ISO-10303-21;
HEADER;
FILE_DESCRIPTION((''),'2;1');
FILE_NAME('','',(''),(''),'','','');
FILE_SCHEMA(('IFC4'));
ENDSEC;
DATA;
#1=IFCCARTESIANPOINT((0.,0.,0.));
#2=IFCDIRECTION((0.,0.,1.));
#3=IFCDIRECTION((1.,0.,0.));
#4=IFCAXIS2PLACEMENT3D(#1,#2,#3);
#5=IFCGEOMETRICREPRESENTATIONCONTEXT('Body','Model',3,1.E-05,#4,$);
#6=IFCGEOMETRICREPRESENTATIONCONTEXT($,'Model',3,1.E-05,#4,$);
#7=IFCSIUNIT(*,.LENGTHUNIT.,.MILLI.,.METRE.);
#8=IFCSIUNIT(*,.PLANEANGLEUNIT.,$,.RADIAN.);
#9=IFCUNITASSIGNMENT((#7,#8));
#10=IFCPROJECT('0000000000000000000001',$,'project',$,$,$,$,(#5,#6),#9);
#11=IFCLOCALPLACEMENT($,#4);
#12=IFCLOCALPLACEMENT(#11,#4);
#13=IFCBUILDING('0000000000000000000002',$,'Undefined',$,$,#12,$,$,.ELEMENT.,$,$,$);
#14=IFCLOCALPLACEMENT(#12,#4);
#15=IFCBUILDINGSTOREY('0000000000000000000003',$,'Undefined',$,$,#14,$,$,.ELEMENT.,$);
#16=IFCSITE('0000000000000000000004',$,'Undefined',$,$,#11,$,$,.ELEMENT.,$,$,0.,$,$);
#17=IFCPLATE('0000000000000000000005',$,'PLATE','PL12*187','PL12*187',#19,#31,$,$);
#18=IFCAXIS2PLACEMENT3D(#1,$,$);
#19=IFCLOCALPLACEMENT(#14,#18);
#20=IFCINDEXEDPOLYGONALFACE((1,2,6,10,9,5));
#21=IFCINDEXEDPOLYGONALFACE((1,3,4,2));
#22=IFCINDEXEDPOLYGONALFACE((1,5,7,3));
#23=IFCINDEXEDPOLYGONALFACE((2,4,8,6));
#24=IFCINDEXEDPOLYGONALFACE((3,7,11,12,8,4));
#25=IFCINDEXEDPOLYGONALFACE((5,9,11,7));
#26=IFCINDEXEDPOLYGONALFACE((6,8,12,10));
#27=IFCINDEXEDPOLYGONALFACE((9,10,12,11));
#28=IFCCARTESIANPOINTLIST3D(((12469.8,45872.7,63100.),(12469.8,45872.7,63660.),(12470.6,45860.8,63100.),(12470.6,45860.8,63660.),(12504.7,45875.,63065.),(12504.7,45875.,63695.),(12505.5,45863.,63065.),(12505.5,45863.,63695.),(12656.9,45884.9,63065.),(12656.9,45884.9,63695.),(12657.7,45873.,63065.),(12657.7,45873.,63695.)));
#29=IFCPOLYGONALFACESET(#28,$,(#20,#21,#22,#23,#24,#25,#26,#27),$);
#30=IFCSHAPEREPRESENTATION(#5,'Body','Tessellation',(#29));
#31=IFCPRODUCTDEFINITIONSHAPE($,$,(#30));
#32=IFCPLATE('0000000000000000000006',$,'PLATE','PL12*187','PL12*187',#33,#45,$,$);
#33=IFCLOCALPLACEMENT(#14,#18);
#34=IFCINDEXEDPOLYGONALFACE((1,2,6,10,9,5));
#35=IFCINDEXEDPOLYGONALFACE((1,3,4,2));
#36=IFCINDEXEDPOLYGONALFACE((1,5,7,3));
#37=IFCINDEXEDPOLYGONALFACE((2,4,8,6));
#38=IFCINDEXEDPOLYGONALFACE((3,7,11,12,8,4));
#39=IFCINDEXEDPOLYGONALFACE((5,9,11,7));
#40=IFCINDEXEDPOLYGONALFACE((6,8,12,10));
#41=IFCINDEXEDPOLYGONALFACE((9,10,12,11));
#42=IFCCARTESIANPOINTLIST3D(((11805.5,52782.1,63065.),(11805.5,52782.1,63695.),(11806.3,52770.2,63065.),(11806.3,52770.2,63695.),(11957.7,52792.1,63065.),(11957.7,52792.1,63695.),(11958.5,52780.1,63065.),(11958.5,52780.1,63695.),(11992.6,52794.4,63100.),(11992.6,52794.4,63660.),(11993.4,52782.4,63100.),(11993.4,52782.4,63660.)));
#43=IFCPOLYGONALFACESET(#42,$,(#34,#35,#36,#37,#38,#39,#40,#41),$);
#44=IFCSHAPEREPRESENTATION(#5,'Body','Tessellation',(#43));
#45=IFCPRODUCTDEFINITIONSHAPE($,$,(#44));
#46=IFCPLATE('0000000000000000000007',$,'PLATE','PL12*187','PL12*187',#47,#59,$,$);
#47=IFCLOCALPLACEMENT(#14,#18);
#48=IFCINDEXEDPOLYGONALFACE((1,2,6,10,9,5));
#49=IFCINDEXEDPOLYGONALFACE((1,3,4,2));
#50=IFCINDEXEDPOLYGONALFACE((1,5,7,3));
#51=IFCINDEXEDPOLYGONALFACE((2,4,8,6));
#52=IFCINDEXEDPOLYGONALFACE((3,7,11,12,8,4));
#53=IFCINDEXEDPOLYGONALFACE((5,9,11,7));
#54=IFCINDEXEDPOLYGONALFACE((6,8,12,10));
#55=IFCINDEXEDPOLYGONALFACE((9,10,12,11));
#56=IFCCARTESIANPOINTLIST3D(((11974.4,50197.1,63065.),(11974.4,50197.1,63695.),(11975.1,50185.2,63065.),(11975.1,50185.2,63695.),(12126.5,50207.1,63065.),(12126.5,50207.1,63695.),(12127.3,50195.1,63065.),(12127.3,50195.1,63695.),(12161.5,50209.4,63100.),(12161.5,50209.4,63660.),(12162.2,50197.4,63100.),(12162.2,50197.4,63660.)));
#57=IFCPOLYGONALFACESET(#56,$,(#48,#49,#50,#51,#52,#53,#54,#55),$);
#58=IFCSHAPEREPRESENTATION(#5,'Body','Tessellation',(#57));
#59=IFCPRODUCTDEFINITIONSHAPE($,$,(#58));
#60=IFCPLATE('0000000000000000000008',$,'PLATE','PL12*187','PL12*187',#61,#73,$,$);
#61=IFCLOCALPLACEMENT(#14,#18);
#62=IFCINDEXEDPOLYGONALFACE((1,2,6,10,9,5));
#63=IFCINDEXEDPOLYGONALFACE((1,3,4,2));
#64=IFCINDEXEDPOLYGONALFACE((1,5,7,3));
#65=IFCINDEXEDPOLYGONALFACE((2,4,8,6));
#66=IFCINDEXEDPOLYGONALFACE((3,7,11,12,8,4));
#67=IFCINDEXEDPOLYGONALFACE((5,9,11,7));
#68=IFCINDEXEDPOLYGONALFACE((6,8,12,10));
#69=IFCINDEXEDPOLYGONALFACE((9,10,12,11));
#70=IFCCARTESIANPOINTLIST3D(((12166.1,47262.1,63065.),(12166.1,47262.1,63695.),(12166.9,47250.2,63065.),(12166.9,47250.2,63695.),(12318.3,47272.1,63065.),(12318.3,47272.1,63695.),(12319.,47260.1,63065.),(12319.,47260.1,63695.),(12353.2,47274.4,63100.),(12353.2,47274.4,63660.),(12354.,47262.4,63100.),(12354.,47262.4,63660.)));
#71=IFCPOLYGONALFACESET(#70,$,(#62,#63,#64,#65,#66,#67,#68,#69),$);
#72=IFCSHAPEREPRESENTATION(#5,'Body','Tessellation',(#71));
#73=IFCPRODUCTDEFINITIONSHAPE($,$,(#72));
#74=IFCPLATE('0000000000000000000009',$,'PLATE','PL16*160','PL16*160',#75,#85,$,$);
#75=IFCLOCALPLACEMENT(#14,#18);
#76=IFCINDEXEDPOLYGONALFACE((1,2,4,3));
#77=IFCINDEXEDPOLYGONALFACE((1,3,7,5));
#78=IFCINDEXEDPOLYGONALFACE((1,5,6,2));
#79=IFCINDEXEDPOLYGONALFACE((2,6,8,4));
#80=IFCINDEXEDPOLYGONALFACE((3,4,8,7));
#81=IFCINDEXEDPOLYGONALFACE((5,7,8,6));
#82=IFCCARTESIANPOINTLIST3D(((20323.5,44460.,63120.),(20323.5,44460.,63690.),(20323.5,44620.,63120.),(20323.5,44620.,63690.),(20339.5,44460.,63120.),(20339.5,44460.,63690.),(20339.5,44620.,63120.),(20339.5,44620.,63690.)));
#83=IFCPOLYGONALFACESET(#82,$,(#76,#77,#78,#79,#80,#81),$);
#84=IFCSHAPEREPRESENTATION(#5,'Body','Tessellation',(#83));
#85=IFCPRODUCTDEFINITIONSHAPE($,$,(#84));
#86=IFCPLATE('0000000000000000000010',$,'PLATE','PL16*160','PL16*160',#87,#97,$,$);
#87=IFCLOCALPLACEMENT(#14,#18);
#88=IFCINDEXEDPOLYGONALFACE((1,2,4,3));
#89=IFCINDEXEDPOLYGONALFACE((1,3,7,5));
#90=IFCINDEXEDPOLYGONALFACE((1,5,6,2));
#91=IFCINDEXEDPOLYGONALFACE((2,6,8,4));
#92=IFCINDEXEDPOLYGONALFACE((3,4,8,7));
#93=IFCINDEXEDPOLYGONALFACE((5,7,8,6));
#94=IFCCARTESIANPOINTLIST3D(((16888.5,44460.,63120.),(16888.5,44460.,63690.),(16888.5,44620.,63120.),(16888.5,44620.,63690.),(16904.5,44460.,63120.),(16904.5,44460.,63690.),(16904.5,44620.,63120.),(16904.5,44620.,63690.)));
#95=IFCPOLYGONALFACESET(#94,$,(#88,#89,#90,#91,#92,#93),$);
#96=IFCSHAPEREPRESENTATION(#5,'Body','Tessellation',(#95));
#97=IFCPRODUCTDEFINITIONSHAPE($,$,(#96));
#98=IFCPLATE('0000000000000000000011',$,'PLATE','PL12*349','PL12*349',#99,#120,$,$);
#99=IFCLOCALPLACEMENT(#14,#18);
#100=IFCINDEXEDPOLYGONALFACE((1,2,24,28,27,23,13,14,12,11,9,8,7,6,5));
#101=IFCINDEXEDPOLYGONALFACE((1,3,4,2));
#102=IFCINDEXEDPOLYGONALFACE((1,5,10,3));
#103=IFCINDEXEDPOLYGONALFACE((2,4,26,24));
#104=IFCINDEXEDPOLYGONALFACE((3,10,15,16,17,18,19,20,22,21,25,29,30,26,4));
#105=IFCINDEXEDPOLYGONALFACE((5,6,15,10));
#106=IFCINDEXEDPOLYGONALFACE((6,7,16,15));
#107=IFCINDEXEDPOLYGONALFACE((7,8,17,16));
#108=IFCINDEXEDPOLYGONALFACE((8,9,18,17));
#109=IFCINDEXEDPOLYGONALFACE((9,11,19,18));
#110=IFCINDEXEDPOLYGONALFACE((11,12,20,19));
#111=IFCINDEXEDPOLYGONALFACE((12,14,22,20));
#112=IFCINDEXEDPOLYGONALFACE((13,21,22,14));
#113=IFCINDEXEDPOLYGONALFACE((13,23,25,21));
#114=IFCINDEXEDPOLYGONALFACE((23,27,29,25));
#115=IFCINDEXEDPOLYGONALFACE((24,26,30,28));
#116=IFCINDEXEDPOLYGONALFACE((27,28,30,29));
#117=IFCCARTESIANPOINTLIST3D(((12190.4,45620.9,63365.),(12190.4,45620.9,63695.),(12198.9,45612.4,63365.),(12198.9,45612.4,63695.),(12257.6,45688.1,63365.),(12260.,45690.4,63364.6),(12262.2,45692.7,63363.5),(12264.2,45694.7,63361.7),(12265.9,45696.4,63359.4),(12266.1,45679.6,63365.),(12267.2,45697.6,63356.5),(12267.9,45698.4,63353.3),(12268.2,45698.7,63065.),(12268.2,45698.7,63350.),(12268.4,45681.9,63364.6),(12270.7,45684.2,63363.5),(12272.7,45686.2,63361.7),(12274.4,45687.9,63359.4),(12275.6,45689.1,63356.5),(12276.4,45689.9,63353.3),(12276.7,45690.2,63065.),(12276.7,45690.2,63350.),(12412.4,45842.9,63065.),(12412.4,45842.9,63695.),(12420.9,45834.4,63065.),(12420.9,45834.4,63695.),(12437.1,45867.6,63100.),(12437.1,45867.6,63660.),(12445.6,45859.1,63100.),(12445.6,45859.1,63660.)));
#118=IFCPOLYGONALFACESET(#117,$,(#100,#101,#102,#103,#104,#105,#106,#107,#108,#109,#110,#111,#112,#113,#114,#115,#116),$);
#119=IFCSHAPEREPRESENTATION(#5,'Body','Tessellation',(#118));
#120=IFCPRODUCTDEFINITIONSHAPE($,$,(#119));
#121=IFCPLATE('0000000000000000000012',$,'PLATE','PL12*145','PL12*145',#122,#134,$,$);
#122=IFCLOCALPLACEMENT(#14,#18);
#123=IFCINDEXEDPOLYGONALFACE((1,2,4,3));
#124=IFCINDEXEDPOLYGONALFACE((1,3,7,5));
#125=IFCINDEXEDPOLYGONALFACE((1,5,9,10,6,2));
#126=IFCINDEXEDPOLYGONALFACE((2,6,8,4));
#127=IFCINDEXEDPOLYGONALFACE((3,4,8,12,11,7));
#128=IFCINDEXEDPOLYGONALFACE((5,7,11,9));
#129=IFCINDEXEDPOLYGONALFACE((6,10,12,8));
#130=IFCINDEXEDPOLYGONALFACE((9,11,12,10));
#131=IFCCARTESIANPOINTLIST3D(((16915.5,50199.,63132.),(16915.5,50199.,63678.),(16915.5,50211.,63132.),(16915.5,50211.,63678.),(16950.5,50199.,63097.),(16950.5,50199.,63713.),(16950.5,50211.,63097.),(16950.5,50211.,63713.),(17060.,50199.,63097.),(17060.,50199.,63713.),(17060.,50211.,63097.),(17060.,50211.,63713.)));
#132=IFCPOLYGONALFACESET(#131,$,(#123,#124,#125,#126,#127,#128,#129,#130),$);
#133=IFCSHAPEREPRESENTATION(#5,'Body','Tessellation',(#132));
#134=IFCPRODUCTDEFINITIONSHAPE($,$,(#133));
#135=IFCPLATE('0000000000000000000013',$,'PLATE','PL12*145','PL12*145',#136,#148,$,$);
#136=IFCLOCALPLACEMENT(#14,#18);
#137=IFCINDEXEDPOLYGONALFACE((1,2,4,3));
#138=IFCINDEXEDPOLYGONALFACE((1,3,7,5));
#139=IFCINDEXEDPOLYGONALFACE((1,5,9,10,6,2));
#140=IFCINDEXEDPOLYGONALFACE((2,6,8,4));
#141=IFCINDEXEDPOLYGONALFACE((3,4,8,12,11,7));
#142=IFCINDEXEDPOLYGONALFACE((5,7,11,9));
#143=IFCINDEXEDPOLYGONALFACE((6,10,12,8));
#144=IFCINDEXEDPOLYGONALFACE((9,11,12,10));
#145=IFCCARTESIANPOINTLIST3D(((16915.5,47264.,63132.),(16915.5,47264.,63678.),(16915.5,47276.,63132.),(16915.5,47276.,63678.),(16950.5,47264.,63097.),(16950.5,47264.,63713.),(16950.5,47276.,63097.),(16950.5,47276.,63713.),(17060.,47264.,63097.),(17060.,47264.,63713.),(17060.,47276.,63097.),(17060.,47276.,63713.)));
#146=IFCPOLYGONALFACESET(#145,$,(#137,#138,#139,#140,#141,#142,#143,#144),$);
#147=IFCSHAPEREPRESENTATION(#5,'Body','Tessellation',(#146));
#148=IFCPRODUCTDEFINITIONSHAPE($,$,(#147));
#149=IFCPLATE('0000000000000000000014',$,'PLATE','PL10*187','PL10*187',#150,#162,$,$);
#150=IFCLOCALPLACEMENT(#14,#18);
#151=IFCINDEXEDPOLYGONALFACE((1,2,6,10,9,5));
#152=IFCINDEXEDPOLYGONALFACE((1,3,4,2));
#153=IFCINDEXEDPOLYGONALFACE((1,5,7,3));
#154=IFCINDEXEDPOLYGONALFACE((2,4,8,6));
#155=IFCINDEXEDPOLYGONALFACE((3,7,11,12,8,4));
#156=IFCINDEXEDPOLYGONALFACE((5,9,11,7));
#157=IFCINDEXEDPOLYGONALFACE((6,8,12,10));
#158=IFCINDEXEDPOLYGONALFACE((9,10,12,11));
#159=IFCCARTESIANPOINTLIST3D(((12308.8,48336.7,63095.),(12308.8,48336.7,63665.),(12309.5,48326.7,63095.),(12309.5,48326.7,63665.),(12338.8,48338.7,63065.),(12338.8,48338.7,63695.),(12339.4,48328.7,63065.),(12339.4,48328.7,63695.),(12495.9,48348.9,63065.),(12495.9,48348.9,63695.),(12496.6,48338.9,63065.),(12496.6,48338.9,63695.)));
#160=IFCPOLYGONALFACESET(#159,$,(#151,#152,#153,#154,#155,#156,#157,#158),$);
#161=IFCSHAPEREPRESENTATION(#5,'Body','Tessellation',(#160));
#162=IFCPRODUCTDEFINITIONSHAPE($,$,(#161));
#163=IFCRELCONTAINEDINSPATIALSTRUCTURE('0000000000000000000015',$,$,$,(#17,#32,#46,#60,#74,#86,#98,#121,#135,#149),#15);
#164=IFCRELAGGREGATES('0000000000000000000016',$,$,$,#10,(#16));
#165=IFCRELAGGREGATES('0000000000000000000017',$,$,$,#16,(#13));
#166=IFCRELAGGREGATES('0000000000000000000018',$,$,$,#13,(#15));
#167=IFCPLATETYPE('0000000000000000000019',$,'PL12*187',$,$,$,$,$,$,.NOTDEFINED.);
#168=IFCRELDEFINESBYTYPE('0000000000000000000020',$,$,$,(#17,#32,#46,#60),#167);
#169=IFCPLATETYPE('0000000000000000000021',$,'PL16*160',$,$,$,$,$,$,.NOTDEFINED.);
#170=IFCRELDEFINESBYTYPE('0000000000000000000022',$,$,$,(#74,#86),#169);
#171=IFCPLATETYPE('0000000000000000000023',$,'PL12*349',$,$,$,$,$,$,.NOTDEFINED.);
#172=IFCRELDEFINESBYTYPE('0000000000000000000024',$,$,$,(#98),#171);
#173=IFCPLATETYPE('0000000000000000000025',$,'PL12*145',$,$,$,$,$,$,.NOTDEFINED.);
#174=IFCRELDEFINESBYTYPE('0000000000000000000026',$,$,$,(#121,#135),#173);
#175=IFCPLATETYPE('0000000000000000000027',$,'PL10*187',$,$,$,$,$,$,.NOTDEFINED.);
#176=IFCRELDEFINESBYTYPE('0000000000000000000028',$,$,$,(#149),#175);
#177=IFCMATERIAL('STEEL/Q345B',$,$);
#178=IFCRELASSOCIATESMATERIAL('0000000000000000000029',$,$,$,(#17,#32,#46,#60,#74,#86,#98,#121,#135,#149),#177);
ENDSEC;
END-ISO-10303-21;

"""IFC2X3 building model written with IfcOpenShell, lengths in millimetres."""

from ifc_helpers import new_model, si_unit, frame, origin_with_axes, place, context, project, spatial, polyline, outline, extrude, material, type_object, element, save


model = new_model("IFC2X3")

# Units and contexts
model_context_1 = context("Model", 3, precision=1e-05, world=origin_with_axes(), identifier="Body")
model_context_2 = context("Model", 3, precision=1e-05, world=origin_with_axes())
ifc_project = project(units=[si_unit("LENGTHUNIT", "METRE", prefix="MILLI"), si_unit("PLANEANGLEUNIT", "RADIAN")], contexts=[model_context_1, model_context_2])

# Site, building, storey
site_placement = place(None, origin_with_axes())
site = spatial("IfcSite", under=ifc_project, at=site_placement, Name="Undefined", CompositionType="ELEMENT", RefElevation=0.0)
building_placement = place(site_placement, origin_with_axes())
building = spatial("IfcBuilding", under=site, at=building_placement, Name="Undefined", CompositionType="ELEMENT")
storey_placement = place(building_placement, origin_with_axes())
storey = spatial("IfcBuildingStorey", under=building, at=storey_placement, Name="Undefined", CompositionType="ELEMENT")

# Shared definitions
ifc_material_1 = material(Name="STEEL/Q345B")

# Plates
plate_type_1 = type_object("IfcPlateType", Name="PL12*187", PredefinedType="NOTDEFINED")
for number, where, z_axis, x_axis, name in (
    (1, (12470.2, 45866.7, 63065.0), (0.065183, -0.997873, 0.0), (0.997873, 0.065184, 0.0), "PLATE"),
    (2, (11993.0, 52788.4, 63065.0), (-0.065184, 0.997873, 0.0), (-0.997873, -0.065183, 0.0), "PLATE"),
    (3, (12161.9, 50203.4, 63065.0), (-0.065184, 0.997873, 0.0), (-0.997873, -0.065183, 0.0), "PLATE"),
    (4, (12353.6, 47268.4, 63065.0), (-0.065184, 0.997873, 0.0), (-0.997873, -0.065183, 0.0), "PLATE"),
):
    element("IfcPlate", number, at=place(storey_placement, frame(where, z_axis=z_axis, x_axis=x_axis)), inside=storey, type_object=plate_type_1, material=ifc_material_1, Name=name, Description="PL12*187", ObjectType="PL12*187", context=model_context_1, shape_type="SweptSolid", body=[
        extrude(outline(polyline([(0.0, 35.0), (35.0, 0.0), (187.5, 0.0), (187.5, 630.0), (35.0, 630.0), (0.0, 595.0), (0.0, 35.0)])), frame((0.0, 0.0, -6.0), z_axis=(0.0, 0.0, 1.0), x_axis=(1.0, 0.0, 0.0)), (0.0, 0.0, 1.0), 12.0),
    ])
plate_type_2 = type_object("IfcPlateType", Name="PL16*160", PredefinedType="NOTDEFINED")
for number, where, z_axis, x_axis, name in (
    (5, (20331.5, 44620.0, 63690.0), (1.0, 0.0, 0.0), (0.0, -1.0, 0.0), "PLATE"),
    (6, (16896.5, 44620.0, 63690.0), (1.0, 0.0, 0.0), (0.0, -1.0, 0.0), "PLATE"),
):
    element("IfcPlate", number, at=place(storey_placement, frame(where, z_axis=z_axis, x_axis=x_axis)), inside=storey, type_object=plate_type_2, material=ifc_material_1, Name=name, Description="PL16*160", ObjectType="PL16*160", context=model_context_1, shape_type="SweptSolid", body=[
        extrude(outline(polyline([(0.0, 0.0), (160.0, 0.0), (160.0, 570.0), (0.0, 570.0), (0.0, 0.0)])), frame((0.0, 0.0, -8.0), z_axis=(0.0, 0.0, 1.0), x_axis=(1.0, 0.0, 0.0)), (0.0, 0.0, 1.0), 16.0),
    ])
plate_type_3 = type_object("IfcPlateType", Name="PL12*349", PredefinedType="NOTDEFINED")
plate_1_placement = place(storey_placement, frame((12194.6, 45616.6, 63695.0), z_axis=(0.707107, -0.707107, 0.0), x_axis=(0.0, 0.0, -1.0)))
element("IfcPlate", 7, at=plate_1_placement, inside=storey, type_object=plate_type_3, material=ifc_material_1, Name="PLATE", Description="PL12*349", ObjectType="PL12*349", context=model_context_1, shape_type="SweptSolid", body=[
    extrude(outline(polyline([(0.0, 0.0), (330.0, 0.0), (330.0, 95.0), (330.4, 98.4), (331.5, 101.5), (333.3, 104.4), (335.6, 106.8), (338.5, 108.5), (341.7, 109.7), (345.0, 110.0), (630.0, 110.0), (630.0, 313.9), (595.0, 348.9), (35.0, 348.9), (0.0, 313.9), (0.0, 0.0)])), frame((0.0, 0.0, -6.0), z_axis=(0.0, 0.0, 1.0), x_axis=(1.0, 0.0, 0.0)), (0.0, 0.0, 1.0), 12.0),
])
plate_type_4 = type_object("IfcPlateType", Name="PL12*145", PredefinedType="NOTDEFINED")
for number, where, z_axis, x_axis, name in (
    (8, (16915.5, 50205.0, 63097.0), (0.0, -1.0, 0.0), (1.0, 0.0, 0.0), "PLATE"),
    (9, (16915.5, 47270.0, 63097.0), (0.0, -1.0, 0.0), (1.0, 0.0, 0.0), "PLATE"),
):
    element("IfcPlate", number, at=place(storey_placement, frame(where, z_axis=z_axis, x_axis=x_axis)), inside=storey, type_object=plate_type_4, material=ifc_material_1, Name=name, Description="PL12*145", ObjectType="PL12*145", context=model_context_1, shape_type="SweptSolid", body=[
        extrude(outline(polyline([(0.0, 35.0), (35.0, 0.0), (144.5, 0.0), (144.5, 616.0), (35.0, 616.0), (0.0, 581.0), (0.0, 35.0)])), frame((0.0, 0.0, -6.0), z_axis=(0.0, 0.0, 1.0), x_axis=(1.0, 0.0, 0.0)), (0.0, 0.0, 1.0), 12.0),
    ])
plate_type_5 = type_object("IfcPlateType", Name="PL10*187", PredefinedType="NOTDEFINED")
plate_2_placement = place(storey_placement, frame((12309.2, 48331.7, 63065.0), z_axis=(0.065183, -0.997873, 0.0), x_axis=(0.997873, 0.065184, 0.0)))
element("IfcPlate", 10, at=plate_2_placement, inside=storey, type_object=plate_type_5, material=ifc_material_1, Name="PLATE", Description="PL10*187", ObjectType="PL10*187", context=model_context_1, shape_type="SweptSolid", body=[
    extrude(outline(polyline([(0.0, 30.0), (30.0, 0.0), (187.5, 0.0), (187.5, 630.0), (30.0, 630.0), (0.0, 600.0), (0.0, 30.0)])), frame((0.0, 0.0, -5.0), z_axis=(0.0, 0.0, 1.0), x_axis=(1.0, 0.0, 0.0)), (0.0, 0.0, 1.0), 10.0),
])

save(model, "model.ifc")
